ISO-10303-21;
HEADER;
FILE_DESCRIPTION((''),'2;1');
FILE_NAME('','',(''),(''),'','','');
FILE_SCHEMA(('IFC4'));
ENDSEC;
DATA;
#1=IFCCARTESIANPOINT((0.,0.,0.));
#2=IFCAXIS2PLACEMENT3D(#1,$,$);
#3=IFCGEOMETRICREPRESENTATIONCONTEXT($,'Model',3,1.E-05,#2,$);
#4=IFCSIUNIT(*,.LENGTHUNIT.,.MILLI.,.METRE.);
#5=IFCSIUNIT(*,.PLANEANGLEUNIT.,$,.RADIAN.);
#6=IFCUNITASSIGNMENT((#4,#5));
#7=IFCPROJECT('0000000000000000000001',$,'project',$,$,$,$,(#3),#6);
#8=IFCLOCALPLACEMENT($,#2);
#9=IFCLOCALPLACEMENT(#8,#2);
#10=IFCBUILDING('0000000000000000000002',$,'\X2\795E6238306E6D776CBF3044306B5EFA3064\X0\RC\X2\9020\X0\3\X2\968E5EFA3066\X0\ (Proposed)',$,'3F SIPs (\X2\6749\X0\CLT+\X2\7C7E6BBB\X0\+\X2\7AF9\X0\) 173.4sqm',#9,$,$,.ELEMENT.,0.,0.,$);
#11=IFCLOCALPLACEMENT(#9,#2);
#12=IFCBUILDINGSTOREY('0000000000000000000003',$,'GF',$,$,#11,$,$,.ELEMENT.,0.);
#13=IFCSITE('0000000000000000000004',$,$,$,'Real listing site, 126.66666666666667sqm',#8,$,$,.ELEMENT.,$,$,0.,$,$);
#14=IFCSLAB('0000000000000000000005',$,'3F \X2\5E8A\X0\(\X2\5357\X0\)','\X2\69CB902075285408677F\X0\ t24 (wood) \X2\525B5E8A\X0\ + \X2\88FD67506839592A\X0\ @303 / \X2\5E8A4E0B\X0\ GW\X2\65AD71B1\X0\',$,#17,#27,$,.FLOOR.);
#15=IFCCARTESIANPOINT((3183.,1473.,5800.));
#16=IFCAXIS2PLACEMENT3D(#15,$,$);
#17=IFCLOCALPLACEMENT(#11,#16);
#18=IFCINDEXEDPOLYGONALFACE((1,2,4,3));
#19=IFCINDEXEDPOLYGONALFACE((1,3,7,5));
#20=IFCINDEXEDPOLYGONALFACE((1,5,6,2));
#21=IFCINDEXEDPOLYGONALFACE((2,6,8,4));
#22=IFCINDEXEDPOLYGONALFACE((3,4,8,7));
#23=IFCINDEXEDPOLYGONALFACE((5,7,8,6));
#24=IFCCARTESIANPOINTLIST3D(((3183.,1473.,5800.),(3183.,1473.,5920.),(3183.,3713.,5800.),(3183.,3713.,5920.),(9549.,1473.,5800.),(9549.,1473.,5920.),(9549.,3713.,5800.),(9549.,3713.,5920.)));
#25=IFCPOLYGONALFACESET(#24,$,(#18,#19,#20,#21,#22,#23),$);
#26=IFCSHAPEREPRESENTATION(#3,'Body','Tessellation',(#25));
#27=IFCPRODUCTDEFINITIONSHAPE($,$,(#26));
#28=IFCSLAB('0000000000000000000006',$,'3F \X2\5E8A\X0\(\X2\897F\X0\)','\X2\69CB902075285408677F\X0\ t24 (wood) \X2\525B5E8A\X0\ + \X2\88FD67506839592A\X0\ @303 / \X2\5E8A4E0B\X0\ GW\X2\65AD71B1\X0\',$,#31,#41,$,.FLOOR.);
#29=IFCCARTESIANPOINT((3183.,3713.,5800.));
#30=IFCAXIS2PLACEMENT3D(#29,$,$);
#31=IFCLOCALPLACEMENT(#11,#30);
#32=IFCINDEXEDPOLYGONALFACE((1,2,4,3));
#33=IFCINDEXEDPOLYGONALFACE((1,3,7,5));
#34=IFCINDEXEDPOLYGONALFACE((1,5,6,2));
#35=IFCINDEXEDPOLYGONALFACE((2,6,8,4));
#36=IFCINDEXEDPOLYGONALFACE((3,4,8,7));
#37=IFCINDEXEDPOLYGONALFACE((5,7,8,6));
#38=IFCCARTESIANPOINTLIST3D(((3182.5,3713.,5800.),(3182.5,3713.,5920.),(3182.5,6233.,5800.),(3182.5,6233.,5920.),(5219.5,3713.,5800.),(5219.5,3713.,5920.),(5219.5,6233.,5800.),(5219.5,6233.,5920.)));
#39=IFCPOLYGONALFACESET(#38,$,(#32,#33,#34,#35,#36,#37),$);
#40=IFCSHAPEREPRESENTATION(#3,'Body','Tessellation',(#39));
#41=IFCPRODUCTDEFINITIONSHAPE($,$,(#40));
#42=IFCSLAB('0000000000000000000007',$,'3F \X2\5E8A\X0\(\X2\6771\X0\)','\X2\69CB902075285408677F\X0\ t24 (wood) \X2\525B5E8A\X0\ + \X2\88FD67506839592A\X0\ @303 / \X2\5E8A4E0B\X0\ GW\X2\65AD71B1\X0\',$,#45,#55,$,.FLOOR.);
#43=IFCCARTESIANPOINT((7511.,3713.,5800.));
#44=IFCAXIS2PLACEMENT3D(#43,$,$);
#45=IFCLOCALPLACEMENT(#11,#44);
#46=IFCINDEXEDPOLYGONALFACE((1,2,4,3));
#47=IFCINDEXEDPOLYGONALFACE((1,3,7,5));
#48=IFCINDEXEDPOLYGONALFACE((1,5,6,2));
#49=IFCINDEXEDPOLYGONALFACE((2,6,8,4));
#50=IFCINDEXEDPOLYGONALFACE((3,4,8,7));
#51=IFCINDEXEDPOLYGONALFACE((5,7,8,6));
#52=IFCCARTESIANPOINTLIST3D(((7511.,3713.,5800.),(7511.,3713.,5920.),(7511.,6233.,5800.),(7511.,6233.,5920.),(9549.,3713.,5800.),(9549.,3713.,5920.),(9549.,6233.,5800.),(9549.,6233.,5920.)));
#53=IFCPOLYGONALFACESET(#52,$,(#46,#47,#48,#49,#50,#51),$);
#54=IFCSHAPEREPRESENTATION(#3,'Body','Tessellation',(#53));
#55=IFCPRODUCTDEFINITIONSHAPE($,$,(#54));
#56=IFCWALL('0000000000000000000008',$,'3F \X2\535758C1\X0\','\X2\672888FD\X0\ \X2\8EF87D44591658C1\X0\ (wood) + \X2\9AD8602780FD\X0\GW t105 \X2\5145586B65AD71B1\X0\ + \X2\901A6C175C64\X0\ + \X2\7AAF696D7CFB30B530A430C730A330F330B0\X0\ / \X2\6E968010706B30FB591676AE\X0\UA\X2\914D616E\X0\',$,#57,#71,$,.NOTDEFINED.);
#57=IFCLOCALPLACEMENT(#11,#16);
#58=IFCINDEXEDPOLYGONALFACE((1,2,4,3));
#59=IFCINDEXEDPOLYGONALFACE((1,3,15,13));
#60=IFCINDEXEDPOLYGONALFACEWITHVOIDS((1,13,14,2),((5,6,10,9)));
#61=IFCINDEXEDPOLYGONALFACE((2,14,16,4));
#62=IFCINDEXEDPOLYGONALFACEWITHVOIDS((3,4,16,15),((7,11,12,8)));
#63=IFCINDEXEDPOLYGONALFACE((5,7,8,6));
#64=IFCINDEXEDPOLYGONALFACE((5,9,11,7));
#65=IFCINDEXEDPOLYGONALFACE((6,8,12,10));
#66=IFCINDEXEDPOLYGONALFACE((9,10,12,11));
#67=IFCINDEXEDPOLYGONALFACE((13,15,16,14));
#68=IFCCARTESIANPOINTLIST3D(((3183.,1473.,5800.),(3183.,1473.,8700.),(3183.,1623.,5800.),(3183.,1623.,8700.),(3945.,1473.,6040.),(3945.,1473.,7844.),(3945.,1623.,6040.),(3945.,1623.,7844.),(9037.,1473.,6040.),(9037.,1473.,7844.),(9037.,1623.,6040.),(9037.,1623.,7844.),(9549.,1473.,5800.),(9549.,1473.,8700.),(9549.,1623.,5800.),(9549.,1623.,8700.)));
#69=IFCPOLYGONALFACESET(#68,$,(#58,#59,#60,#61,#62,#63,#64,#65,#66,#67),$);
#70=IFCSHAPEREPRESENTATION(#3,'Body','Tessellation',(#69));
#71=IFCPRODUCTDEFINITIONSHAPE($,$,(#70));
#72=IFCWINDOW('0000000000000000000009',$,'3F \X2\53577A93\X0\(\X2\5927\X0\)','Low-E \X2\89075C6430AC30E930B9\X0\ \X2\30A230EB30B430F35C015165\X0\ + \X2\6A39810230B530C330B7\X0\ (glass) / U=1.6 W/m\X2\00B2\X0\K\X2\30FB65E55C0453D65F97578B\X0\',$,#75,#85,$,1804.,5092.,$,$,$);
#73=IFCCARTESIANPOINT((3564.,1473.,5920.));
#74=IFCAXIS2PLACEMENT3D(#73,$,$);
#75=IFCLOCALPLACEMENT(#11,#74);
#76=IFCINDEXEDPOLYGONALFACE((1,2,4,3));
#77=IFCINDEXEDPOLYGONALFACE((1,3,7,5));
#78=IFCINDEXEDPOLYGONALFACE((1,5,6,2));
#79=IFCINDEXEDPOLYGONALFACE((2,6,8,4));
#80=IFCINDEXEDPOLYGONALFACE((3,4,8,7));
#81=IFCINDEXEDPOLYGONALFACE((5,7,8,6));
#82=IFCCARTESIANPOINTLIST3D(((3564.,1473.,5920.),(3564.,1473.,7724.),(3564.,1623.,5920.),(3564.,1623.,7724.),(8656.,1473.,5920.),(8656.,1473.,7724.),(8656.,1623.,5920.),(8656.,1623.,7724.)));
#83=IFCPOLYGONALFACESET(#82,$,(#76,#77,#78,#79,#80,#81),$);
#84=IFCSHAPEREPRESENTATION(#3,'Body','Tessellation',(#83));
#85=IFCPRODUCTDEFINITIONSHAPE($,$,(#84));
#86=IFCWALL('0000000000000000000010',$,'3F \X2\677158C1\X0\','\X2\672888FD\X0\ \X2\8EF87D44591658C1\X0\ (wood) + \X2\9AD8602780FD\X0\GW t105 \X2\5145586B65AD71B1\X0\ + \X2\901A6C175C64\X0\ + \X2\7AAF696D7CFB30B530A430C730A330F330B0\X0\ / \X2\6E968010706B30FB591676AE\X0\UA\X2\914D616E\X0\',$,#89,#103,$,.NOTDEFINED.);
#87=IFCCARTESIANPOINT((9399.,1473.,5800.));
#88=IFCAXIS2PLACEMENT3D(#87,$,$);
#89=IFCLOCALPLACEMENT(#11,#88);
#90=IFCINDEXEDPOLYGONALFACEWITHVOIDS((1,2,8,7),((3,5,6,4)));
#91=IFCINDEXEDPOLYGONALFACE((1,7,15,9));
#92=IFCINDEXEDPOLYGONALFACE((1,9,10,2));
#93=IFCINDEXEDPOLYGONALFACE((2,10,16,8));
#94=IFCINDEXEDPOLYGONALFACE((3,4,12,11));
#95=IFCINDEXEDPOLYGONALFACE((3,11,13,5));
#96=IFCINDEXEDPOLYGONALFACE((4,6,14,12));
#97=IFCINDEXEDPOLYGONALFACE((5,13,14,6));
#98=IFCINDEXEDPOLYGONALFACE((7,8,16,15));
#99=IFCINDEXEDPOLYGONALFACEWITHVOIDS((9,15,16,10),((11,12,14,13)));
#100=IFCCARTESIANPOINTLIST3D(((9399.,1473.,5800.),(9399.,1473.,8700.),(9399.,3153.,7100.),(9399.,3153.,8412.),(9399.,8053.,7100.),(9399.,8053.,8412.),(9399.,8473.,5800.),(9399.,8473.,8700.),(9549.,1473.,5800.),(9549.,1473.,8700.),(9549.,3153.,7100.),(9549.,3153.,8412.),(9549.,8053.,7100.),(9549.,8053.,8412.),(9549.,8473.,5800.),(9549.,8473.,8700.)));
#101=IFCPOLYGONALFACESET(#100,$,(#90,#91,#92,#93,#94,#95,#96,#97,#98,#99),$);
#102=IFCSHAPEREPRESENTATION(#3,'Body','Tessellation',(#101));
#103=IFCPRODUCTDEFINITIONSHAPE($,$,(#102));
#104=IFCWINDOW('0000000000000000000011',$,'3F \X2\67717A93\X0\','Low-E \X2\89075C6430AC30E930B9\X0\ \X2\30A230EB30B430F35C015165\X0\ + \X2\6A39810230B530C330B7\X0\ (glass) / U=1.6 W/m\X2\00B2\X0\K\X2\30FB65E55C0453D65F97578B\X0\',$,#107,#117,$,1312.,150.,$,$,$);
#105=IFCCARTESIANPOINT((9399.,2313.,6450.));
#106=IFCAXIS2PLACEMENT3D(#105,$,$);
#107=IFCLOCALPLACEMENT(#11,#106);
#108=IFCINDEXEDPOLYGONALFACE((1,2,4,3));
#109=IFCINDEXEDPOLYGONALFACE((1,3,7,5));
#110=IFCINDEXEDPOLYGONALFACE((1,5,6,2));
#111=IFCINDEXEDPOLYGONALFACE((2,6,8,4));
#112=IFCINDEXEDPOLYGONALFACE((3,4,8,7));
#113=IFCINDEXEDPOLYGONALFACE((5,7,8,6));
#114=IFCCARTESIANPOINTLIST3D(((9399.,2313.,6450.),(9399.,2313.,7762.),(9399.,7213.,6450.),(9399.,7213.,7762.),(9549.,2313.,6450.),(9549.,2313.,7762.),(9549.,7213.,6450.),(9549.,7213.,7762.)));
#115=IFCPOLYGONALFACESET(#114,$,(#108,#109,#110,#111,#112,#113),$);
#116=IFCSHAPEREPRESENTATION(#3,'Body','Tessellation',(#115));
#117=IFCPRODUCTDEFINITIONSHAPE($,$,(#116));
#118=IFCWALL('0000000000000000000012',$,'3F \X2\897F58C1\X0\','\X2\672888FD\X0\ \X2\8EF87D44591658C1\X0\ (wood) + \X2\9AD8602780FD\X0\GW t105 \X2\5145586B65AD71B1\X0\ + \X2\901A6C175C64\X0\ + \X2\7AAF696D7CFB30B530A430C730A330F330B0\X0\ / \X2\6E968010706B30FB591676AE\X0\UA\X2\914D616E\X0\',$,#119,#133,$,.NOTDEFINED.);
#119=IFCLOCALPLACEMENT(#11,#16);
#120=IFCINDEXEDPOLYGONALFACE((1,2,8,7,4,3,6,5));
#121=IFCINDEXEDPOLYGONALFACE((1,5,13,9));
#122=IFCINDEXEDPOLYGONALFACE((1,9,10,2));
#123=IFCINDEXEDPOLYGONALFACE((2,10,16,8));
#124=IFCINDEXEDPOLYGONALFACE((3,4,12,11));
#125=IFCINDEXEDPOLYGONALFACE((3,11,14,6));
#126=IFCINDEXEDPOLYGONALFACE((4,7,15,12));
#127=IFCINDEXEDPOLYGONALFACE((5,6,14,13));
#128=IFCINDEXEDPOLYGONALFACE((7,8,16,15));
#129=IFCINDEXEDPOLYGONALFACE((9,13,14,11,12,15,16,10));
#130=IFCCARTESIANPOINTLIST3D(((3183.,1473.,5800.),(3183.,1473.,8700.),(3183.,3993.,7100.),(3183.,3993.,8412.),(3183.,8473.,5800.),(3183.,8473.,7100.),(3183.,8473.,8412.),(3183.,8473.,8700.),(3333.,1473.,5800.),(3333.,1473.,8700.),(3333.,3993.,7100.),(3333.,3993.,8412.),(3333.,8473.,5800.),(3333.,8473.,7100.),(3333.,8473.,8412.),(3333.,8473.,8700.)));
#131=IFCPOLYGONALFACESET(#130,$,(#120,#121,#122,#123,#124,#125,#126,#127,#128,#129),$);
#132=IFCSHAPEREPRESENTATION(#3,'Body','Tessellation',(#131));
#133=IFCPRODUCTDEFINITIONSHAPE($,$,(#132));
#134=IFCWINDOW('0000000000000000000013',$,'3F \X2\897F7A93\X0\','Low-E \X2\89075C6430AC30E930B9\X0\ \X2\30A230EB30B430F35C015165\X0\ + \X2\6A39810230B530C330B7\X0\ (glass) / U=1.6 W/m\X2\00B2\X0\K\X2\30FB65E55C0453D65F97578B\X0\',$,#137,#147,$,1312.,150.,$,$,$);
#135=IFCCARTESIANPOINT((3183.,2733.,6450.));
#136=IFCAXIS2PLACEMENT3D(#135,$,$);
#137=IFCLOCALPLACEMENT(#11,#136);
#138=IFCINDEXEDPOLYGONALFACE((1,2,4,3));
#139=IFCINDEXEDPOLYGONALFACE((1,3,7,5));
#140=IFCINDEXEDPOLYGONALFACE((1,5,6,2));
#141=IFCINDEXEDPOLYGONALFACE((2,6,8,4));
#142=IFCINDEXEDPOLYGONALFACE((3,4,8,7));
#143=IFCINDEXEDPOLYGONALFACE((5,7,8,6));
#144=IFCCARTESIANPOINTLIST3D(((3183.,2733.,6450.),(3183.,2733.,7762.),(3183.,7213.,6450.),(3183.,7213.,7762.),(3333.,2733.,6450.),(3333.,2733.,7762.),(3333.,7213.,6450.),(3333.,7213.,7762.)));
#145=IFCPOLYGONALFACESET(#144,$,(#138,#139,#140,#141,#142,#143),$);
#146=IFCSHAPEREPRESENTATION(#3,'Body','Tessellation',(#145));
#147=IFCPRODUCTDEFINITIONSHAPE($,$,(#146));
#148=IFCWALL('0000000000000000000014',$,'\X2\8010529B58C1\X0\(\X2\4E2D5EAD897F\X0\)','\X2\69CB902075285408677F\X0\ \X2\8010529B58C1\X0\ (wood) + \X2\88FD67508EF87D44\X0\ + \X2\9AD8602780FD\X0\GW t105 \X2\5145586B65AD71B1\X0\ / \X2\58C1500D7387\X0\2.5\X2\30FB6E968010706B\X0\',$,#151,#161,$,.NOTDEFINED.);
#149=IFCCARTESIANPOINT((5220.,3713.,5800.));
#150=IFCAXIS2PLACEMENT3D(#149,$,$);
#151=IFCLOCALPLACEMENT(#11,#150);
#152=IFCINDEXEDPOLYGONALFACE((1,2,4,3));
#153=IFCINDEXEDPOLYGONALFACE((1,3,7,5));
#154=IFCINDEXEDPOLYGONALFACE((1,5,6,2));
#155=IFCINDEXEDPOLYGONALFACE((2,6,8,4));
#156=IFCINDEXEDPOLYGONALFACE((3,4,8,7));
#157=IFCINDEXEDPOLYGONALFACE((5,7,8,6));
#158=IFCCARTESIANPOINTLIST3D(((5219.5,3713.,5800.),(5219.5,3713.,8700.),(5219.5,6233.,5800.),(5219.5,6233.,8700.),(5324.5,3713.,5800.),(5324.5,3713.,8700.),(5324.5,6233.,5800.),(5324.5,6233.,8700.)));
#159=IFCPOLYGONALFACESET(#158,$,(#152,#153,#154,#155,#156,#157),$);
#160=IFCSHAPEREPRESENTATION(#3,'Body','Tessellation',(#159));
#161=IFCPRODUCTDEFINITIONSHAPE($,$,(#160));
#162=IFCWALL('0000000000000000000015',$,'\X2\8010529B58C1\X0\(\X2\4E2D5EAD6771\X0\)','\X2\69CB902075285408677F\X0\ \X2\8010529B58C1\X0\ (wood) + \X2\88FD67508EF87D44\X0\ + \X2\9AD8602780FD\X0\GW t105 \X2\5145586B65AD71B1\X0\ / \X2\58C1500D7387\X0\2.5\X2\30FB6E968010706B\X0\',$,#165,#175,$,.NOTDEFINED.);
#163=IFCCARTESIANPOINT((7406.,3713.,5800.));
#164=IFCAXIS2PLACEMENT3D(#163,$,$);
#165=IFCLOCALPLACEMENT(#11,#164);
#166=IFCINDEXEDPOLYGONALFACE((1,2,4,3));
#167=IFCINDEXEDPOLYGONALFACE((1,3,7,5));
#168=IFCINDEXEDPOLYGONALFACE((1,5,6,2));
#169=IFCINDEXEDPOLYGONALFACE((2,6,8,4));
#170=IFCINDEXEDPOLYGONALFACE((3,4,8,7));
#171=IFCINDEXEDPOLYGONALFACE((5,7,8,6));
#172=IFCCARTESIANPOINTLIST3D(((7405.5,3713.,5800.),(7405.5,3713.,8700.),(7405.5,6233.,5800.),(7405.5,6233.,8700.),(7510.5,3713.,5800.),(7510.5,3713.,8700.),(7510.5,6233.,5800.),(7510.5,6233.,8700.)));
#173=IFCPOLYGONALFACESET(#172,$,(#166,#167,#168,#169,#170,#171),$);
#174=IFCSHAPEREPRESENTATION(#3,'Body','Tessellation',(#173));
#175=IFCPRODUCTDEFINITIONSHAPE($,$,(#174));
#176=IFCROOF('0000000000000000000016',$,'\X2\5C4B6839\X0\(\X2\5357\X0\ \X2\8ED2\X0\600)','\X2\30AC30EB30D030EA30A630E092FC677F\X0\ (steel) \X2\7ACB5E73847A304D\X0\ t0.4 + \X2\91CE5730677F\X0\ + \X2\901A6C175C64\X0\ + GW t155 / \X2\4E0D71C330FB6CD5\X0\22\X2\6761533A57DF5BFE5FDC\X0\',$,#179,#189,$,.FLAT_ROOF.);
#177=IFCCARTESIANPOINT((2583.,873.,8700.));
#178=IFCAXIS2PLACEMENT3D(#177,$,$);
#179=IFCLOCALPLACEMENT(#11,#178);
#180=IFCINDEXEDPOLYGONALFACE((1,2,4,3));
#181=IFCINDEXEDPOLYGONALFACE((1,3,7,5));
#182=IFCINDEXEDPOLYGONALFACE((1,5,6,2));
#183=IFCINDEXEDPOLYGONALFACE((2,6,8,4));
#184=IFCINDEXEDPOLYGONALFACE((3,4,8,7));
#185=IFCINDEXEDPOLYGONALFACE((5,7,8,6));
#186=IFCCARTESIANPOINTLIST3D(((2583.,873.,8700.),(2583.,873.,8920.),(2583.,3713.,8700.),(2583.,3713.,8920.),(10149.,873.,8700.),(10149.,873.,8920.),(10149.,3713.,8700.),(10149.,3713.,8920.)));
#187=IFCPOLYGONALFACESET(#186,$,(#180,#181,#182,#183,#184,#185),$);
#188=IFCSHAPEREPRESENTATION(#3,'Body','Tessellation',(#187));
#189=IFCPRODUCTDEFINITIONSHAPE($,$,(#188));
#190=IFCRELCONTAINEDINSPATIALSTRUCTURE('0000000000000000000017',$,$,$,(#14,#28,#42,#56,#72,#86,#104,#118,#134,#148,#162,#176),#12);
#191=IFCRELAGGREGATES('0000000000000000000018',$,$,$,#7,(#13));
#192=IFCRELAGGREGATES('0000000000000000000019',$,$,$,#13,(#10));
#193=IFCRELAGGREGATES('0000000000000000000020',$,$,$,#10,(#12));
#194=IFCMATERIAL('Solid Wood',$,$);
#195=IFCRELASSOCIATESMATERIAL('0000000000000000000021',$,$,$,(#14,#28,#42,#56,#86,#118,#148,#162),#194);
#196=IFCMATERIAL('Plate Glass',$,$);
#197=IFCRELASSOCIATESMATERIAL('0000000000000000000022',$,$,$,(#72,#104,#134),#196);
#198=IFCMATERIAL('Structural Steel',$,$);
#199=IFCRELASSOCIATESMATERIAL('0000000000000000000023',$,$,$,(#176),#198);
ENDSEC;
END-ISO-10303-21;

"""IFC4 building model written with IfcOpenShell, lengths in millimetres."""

from ifc_helpers import new_model, si_unit, frame, frame_2d, origin, place, context, project, spatial, rectangle, extrude, material, element, fill, save


model = new_model("IFC4")

# Units and contexts
model_context = context("Model", 3, precision=1e-05, world=origin())
ifc_project = project(units=[si_unit("LENGTHUNIT", "METRE", prefix="MILLI"), si_unit("PLANEANGLEUNIT", "RADIAN")], contexts=[model_context])

# Site, building, storey
site_placement = place(None, origin())
site = spatial("IfcSite", under=ifc_project, at=site_placement, ObjectType="Real listing site, 126.66666666666667sqm", CompositionType="ELEMENT", RefElevation=0.0)
building_placement = place(site_placement, origin())
building = spatial("IfcBuilding", under=site, at=building_placement, Name="神戸の海沿いに建つRC造3階建て (Proposed)", ObjectType="3F SIPs (杉CLT+籾殻+竹) 173.4sqm", CompositionType="ELEMENT", ElevationOfRefHeight=0.0, ElevationOfTerrain=0.0)
storey_placement = place(building_placement, origin())
storey = spatial("IfcBuildingStorey", under=building, at=storey_placement, Name="GF", CompositionType="ELEMENT", Elevation=0.0)

# Slabs
ifc_material_1 = material(Name="Solid Wood")
slab_1_placement = place(storey_placement, frame((3183.0, 1473.0, 5800.0)))
element("IfcSlab", 1, at=slab_1_placement, inside=storey, material=ifc_material_1, Name="3F 床(南)", Description="構造用合板 t24 (wood) 剛床 + 製材根太 @303 / 床下 GW断熱", PredefinedType="FLOOR", context=model_context, shape_type="SweptSolid", body=[
    extrude(rectangle(XDim=6366.0, YDim=2240.0, at=frame_2d((3183.0, 1120.0))), frame((3183.0, 1473.0, 5800.0)), (0.0, 0.0, 1.0), 120.0),
])
slab_2_placement = place(storey_placement, frame((3183.0, 3713.0, 5800.0)))
element("IfcSlab", 2, at=slab_2_placement, inside=storey, material=ifc_material_1, Name="3F 床(西)", Description="構造用合板 t24 (wood) 剛床 + 製材根太 @303 / 床下 GW断熱", PredefinedType="FLOOR", context=model_context, shape_type="SweptSolid", body=[
    extrude(rectangle(XDim=2037.0, YDim=2520.0, at=frame_2d((1018.0, 1260.0))), frame((3183.0, 3713.0, 5800.0)), (0.0, 0.0, 1.0), 120.0),
])
slab_3_placement = place(storey_placement, frame((7511.0, 3713.0, 5800.0)))
element("IfcSlab", 3, at=slab_3_placement, inside=storey, material=ifc_material_1, Name="3F 床(東)", Description="構造用合板 t24 (wood) 剛床 + 製材根太 @303 / 床下 GW断熱", PredefinedType="FLOOR", context=model_context, shape_type="SweptSolid", body=[
    extrude(rectangle(XDim=2038.0, YDim=2520.0, at=frame_2d((1019.0, 1260.0))), frame((7511.0, 3713.0, 5800.0)), (0.0, 0.0, 1.0), 120.0),
])

# Walls, openings, windows
wall_1_placement = place(storey_placement, frame((3183.0, 1473.0, 5800.0)))
wall_1 = element("IfcWall", 4, at=wall_1_placement, inside=storey, material=ifc_material_1, Name="3F 南壁", Description="木製 軸組外壁 (wood) + 高性能GW t105 充填断熱 + 通気層 + 窯業系サイディング / 準耐火・外皮UA配慮", PredefinedType="NOTDEFINED", context=model_context, shape_type="SweptSolid", body=[
    extrude(rectangle(XDim=6366.0, YDim=150.0, at=frame_2d((3183.0, 75.0))), frame((3183.0, 1473.0, 5800.0)), (0.0, 0.0, 1.0), 2900.0),
])
opening_1_placement = place(storey_placement, frame((3564.0, 1473.0, 5920.0)))
opening_1 = element("IfcOpeningElement", 5, at=opening_1_placement, cuts=wall_1, PredefinedType="NOTDEFINED", context=model_context, shape_type="SweptSolid", body=[
    extrude(rectangle(XDim=5092.0, YDim=150.0, at=frame_2d((2546.0, 75.0))), frame((3564.0, 1473.0, 5920.0)), (0.0, 0.0, 1.0), 1804.0),
])
ifc_material_2 = material(Name="Plate Glass")
window_1_placement = place(storey_placement, frame((3564.0, 1473.0, 5920.0)))
window_1 = element("IfcWindow", 6, at=window_1_placement, inside=storey, material=ifc_material_2, Name="3F 南窓(大)", Description="Low-E 複層ガラス アルゴン封入 + 樹脂サッシ (glass) / U=1.6 W/m²K・日射取得型", OverallHeight=1804.0, OverallWidth=5092.0, context=model_context, shape_type="SweptSolid", body=[
    extrude(rectangle(XDim=5092.0, YDim=150.0, at=frame_2d((2546.0, 75.0))), frame((3564.0, 1473.0, 5920.0)), (0.0, 0.0, 1.0), 1804.0),
])
fill(opening_1, window_1)
wall_2_placement = place(storey_placement, frame((9399.0, 1473.0, 5800.0)))
wall_2 = element("IfcWall", 7, at=wall_2_placement, inside=storey, material=ifc_material_1, Name="3F 東壁", Description="木製 軸組外壁 (wood) + 高性能GW t105 充填断熱 + 通気層 + 窯業系サイディング / 準耐火・外皮UA配慮", PredefinedType="NOTDEFINED", context=model_context, shape_type="SweptSolid", body=[
    extrude(rectangle(XDim=150.0, YDim=7000.0, at=frame_2d((75.0, 3500.0))), frame((9399.0, 1473.0, 5800.0)), (0.0, 0.0, 1.0), 2900.0),
])
opening_2_placement = place(storey_placement, frame((9399.0, 2313.0, 6450.0)))
opening_2 = element("IfcOpeningElement", 8, at=opening_2_placement, cuts=wall_2, PredefinedType="NOTDEFINED", context=model_context, shape_type="SweptSolid", body=[
    extrude(rectangle(XDim=150.0, YDim=4900.0, at=frame_2d((75.0, 2450.0))), frame((9399.0, 2313.0, 6450.0)), (0.0, 0.0, 1.0), 1312.0),
])
window_2_placement = place(storey_placement, frame((9399.0, 2313.0, 6450.0)))
window_2 = element("IfcWindow", 9, at=window_2_placement, inside=storey, material=ifc_material_2, Name="3F 東窓", Description="Low-E 複層ガラス アルゴン封入 + 樹脂サッシ (glass) / U=1.6 W/m²K・日射取得型", OverallHeight=1312.0, OverallWidth=150.0, context=model_context, shape_type="SweptSolid", body=[
    extrude(rectangle(XDim=150.0, YDim=4900.0, at=frame_2d((75.0, 2450.0))), frame((9399.0, 2313.0, 6450.0)), (0.0, 0.0, 1.0), 1312.0),
])
fill(opening_2, window_2)
wall_3_placement = place(storey_placement, frame((3183.0, 1473.0, 5800.0)))
wall_3 = element("IfcWall", 10, at=wall_3_placement, inside=storey, material=ifc_material_1, Name="3F 西壁", Description="木製 軸組外壁 (wood) + 高性能GW t105 充填断熱 + 通気層 + 窯業系サイディング / 準耐火・外皮UA配慮", PredefinedType="NOTDEFINED", context=model_context, shape_type="SweptSolid", body=[
    extrude(rectangle(XDim=150.0, YDim=7000.0, at=frame_2d((75.0, 3500.0))), frame((3183.0, 1473.0, 5800.0)), (0.0, 0.0, 1.0), 2900.0),
])
opening_3_placement = place(storey_placement, frame((3183.0, 2733.0, 6450.0)))
opening_3 = element("IfcOpeningElement", 11, at=opening_3_placement, cuts=wall_3, PredefinedType="NOTDEFINED", context=model_context, shape_type="SweptSolid", body=[
    extrude(rectangle(XDim=150.0, YDim=4480.0, at=frame_2d((75.0, 2240.0))), frame((3183.0, 2733.0, 6450.0)), (0.0, 0.0, 1.0), 1312.0),
])
window_3_placement = place(storey_placement, frame((3183.0, 2733.0, 6450.0)))
window_3 = element("IfcWindow", 12, at=window_3_placement, inside=storey, material=ifc_material_2, Name="3F 西窓", Description="Low-E 複層ガラス アルゴン封入 + 樹脂サッシ (glass) / U=1.6 W/m²K・日射取得型", OverallHeight=1312.0, OverallWidth=150.0, context=model_context, shape_type="SweptSolid", body=[
    extrude(rectangle(XDim=150.0, YDim=4480.0, at=frame_2d((75.0, 2240.0))), frame((3183.0, 2733.0, 6450.0)), (0.0, 0.0, 1.0), 1312.0),
])
fill(opening_3, window_3)

# Walls
wall_4_placement = place(storey_placement, frame((5220.0, 3713.0, 5800.0)))
element("IfcWall", 13, at=wall_4_placement, inside=storey, material=ifc_material_1, Name="耐力壁(中庭西)", Description="構造用合板 耐力壁 (wood) + 製材軸組 + 高性能GW t105 充填断熱 / 壁倍率2.5・準耐火", PredefinedType="NOTDEFINED", context=model_context, shape_type="SweptSolid", body=[
    extrude(rectangle(XDim=105.0, YDim=2520.0, at=frame_2d((52.0, 1260.0))), frame((5220.0, 3713.0, 5800.0)), (0.0, 0.0, 1.0), 2900.0),
])
wall_5_placement = place(storey_placement, frame((7406.0, 3713.0, 5800.0)))
element("IfcWall", 14, at=wall_5_placement, inside=storey, material=ifc_material_1, Name="耐力壁(中庭東)", Description="構造用合板 耐力壁 (wood) + 製材軸組 + 高性能GW t105 充填断熱 / 壁倍率2.5・準耐火", PredefinedType="NOTDEFINED", context=model_context, shape_type="SweptSolid", body=[
    extrude(rectangle(XDim=105.0, YDim=2520.0, at=frame_2d((52.0, 1260.0))), frame((7406.0, 3713.0, 5800.0)), (0.0, 0.0, 1.0), 2900.0),
])

# Roof
ifc_material_3 = material(Name="Structural Steel")
roof_1_placement = place(storey_placement, frame((2583.0, 873.0, 8700.0)))
element("IfcRoof", 15, at=roof_1_placement, inside=storey, material=ifc_material_3, Name="屋根(南 軒600)", Description="ガルバリウム鋼板 (steel) 立平葺き t0.4 + 野地板 + 通気層 + GW t155 / 不燃・法22条区域対応", PredefinedType="FLAT_ROOF", context=model_context, shape_type="SweptSolid", body=[
    extrude(rectangle(XDim=7566.0, YDim=2840.0, at=frame_2d((3783.0, 1420.0))), frame((2583.0, 873.0, 8700.0)), (0.0, 0.0, 1.0), 220.0),
])

save(model, "model.ifc")
